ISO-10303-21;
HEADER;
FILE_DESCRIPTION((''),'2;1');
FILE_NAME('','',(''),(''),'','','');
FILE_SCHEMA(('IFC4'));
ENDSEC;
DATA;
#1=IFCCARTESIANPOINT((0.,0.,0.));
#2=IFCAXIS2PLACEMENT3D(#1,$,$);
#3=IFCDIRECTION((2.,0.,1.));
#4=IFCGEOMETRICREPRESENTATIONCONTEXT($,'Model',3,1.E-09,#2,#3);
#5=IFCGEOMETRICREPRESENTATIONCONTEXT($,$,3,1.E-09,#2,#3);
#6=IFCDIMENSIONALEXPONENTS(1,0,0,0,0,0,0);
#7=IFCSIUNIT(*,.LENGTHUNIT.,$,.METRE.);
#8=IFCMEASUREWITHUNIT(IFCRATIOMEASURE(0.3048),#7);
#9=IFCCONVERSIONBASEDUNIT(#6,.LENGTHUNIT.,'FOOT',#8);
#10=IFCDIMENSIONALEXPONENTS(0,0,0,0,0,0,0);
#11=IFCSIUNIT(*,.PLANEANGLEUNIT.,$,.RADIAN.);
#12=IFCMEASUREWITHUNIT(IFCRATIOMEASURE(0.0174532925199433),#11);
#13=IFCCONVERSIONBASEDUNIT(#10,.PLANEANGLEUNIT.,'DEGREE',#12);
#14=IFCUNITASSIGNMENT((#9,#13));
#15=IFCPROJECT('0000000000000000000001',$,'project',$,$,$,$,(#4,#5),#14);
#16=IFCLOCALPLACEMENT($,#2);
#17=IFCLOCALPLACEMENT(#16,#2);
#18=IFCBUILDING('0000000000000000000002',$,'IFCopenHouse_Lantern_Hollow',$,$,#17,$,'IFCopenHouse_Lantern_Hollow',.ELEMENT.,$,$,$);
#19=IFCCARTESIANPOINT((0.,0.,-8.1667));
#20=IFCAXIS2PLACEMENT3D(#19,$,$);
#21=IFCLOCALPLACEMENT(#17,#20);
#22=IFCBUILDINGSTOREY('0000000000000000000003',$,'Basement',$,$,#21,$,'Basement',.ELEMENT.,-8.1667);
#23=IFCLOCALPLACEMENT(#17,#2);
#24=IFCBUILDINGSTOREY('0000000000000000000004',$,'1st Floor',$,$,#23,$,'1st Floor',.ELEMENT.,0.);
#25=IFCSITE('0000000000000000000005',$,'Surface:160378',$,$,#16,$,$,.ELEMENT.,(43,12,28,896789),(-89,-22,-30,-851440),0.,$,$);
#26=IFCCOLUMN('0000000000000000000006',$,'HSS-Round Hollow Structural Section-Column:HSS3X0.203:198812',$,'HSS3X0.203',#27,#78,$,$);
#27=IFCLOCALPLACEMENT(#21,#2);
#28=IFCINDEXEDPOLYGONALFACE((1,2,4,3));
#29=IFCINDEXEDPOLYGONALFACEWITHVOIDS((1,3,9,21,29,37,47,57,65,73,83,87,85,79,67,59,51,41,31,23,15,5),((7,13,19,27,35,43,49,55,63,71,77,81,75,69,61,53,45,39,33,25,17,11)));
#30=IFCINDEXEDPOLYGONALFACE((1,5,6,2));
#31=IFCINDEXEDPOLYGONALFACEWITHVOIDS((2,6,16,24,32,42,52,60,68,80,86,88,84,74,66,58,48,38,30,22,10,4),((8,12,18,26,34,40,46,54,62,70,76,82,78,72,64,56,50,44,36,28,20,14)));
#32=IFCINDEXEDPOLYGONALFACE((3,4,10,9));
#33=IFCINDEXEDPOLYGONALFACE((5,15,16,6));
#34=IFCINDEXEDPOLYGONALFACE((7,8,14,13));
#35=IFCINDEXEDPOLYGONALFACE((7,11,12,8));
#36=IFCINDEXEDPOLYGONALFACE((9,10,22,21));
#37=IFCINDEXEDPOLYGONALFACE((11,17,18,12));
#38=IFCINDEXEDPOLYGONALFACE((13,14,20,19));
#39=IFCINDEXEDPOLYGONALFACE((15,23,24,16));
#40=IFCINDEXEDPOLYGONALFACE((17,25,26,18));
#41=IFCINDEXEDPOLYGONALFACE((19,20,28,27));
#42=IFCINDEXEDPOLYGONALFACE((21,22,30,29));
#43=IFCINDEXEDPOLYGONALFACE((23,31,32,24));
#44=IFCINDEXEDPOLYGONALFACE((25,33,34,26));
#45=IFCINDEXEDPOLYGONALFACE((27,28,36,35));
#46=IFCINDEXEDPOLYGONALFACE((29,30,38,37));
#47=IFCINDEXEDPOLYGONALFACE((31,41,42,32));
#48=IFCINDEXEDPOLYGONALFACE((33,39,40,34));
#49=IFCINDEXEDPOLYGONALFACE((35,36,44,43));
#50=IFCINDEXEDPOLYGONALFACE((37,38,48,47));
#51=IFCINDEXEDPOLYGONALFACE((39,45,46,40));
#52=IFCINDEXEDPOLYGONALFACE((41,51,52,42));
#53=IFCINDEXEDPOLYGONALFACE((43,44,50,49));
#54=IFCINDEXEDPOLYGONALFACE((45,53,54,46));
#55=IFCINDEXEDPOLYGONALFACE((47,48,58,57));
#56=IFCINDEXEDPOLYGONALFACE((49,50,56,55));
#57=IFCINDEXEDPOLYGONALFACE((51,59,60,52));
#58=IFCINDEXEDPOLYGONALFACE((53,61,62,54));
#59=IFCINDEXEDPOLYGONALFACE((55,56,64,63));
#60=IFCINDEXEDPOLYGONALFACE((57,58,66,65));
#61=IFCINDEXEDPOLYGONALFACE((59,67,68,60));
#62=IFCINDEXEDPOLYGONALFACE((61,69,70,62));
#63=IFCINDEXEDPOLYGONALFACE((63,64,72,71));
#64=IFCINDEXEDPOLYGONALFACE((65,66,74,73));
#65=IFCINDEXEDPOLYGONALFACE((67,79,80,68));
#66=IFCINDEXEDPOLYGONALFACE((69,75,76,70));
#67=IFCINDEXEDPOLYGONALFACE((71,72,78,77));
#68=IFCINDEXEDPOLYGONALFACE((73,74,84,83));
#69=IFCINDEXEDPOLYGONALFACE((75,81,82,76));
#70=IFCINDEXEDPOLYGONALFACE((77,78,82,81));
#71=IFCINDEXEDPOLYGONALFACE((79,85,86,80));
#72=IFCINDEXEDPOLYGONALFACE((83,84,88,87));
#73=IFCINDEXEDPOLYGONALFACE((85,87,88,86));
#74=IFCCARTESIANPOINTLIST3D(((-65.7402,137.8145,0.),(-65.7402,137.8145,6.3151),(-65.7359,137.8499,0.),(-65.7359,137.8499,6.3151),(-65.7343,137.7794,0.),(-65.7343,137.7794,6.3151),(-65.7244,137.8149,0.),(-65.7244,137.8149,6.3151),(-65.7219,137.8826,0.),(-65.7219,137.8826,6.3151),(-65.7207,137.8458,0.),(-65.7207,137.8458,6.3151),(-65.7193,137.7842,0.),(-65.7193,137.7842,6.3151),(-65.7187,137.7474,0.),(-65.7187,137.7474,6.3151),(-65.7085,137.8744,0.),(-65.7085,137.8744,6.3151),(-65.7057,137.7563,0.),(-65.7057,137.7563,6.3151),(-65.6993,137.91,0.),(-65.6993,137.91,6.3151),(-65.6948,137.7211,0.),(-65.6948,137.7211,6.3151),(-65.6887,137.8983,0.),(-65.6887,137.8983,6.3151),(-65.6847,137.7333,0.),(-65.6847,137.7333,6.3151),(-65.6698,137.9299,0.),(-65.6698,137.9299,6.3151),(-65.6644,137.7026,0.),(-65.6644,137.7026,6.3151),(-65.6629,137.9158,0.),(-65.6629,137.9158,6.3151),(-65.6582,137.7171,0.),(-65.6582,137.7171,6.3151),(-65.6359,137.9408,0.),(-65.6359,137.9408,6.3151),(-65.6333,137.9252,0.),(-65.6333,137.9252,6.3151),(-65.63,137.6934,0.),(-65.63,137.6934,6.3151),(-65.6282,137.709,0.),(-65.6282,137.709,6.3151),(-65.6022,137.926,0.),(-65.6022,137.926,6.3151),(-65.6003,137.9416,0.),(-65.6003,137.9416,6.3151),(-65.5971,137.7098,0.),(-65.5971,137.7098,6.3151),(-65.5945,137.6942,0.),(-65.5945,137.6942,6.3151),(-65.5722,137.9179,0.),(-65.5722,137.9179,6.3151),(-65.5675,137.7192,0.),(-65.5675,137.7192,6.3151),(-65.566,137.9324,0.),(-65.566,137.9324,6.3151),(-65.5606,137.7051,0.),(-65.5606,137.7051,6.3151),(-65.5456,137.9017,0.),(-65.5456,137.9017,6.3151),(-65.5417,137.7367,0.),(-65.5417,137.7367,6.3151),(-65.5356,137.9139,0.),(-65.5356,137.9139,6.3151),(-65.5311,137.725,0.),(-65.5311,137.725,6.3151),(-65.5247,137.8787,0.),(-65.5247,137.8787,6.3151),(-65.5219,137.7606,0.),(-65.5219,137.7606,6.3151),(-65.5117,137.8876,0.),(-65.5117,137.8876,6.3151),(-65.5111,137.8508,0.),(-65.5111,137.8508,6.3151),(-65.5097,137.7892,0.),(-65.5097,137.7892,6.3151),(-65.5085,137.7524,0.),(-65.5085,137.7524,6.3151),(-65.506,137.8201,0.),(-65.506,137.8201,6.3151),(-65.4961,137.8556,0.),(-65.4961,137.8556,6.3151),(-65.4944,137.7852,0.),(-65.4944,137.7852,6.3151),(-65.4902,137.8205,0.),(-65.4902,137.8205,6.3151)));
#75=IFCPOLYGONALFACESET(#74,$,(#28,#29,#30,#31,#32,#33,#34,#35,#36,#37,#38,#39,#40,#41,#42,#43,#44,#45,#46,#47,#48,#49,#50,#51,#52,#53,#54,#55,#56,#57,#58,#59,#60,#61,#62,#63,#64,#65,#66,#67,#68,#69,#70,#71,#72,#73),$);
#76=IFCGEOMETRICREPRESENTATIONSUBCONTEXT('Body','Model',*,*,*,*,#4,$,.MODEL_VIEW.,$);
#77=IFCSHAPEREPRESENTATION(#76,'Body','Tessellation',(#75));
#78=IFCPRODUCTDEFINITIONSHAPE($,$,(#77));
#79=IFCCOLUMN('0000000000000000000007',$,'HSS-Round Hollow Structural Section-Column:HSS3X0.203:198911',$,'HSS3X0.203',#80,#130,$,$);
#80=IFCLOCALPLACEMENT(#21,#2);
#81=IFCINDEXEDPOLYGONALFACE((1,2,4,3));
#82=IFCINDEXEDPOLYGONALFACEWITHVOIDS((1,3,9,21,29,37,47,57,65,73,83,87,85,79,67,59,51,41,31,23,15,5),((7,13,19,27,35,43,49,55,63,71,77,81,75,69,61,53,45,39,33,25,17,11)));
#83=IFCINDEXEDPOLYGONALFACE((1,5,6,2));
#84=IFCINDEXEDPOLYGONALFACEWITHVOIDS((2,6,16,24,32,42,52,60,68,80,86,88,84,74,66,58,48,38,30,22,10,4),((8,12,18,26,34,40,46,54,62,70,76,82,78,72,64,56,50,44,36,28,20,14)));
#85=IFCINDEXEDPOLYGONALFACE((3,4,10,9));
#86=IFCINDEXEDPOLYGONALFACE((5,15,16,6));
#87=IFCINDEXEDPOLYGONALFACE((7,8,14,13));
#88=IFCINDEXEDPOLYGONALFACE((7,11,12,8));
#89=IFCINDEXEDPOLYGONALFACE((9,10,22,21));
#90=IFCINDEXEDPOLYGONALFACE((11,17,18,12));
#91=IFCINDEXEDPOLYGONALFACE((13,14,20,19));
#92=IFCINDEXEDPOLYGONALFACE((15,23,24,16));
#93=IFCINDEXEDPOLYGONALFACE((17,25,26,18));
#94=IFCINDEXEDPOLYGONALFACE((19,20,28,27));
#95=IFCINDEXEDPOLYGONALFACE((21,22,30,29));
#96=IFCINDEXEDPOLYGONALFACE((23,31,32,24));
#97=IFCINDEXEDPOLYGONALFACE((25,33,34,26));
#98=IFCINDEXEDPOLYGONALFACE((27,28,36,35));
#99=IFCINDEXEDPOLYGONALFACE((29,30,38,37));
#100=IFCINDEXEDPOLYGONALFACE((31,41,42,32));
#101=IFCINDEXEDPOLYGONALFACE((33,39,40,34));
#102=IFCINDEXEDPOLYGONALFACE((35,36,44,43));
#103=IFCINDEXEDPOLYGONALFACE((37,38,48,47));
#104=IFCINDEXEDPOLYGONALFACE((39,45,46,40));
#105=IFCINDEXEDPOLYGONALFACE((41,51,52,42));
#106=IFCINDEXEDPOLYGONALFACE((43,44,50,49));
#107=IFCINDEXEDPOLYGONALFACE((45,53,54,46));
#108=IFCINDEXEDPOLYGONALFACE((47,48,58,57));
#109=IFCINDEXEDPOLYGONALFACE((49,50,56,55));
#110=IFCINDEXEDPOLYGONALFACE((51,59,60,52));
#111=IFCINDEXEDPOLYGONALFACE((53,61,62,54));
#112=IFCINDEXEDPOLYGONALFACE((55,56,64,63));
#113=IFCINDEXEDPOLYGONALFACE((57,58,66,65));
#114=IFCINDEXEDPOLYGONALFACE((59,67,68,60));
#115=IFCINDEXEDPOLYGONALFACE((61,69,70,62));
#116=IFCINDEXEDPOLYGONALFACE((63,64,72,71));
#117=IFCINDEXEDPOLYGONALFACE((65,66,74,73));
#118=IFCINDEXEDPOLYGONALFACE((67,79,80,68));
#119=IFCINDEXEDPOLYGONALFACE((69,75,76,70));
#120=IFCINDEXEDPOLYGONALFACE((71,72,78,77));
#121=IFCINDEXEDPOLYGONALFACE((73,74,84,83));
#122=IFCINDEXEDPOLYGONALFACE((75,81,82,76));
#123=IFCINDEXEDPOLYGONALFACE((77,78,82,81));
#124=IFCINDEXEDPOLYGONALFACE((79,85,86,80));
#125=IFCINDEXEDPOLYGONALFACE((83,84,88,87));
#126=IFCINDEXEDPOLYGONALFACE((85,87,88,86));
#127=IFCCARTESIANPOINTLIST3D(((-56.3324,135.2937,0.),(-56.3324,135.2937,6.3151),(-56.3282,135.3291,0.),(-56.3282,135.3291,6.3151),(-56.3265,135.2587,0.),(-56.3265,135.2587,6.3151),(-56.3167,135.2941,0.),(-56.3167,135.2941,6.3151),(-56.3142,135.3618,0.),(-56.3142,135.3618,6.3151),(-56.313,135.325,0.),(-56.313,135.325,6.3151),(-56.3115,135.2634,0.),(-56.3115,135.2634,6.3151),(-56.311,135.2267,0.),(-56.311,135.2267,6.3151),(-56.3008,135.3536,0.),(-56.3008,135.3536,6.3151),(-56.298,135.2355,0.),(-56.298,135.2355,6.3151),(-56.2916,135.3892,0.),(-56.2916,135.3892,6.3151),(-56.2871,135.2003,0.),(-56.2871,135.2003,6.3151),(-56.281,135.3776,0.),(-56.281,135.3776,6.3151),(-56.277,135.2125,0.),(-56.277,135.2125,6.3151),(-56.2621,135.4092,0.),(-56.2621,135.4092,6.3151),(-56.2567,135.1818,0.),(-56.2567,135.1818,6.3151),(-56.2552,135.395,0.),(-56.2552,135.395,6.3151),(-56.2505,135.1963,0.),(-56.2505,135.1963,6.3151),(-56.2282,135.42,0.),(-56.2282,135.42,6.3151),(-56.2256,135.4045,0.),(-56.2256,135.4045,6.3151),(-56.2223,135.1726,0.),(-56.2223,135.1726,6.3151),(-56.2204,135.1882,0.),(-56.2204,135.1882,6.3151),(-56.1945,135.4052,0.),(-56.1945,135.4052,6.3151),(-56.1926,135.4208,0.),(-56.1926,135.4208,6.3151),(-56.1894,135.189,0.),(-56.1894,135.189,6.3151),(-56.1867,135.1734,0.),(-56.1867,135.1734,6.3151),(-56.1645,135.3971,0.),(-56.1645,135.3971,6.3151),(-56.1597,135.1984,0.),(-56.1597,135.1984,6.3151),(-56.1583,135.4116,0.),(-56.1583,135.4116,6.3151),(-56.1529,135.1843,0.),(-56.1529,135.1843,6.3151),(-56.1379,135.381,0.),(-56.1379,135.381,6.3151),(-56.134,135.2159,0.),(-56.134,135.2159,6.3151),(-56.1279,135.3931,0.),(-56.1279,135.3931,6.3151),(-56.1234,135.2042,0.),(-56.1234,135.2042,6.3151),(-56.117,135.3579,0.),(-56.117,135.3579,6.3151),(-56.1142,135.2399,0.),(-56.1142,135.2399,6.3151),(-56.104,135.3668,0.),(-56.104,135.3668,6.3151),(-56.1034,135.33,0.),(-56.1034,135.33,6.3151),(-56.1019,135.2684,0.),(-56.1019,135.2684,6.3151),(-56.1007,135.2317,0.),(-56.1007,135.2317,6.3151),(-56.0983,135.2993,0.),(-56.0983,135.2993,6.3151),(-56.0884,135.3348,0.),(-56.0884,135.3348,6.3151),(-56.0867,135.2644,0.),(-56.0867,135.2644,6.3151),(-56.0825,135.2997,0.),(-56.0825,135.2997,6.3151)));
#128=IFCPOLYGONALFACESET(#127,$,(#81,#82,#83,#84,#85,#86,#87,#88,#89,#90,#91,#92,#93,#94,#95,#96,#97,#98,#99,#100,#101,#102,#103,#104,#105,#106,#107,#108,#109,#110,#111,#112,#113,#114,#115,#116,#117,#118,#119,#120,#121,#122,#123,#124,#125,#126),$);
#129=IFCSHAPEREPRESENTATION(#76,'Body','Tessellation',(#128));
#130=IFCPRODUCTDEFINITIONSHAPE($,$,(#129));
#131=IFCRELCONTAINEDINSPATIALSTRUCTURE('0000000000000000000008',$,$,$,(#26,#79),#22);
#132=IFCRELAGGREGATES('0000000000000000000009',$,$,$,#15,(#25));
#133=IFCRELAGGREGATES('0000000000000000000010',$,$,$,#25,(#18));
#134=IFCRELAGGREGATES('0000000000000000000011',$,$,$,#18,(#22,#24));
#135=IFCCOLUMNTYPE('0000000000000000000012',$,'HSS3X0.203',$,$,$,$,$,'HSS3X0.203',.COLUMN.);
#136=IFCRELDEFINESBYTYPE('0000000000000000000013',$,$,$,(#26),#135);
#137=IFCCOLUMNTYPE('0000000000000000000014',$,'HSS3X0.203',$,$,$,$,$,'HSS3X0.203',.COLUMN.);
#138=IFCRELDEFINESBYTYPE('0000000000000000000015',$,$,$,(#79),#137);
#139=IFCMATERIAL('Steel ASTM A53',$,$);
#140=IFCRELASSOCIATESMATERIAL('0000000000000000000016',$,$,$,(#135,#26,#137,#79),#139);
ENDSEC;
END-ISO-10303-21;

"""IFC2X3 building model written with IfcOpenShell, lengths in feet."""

from ifc_helpers import new_model, entity, si_unit, converted_unit, direction, frame, frame_2d, origin, place, context, subcontext, project, spatial, circle_curve, parameter, trimmed, segment, composite_curve, outline, extrude, source, transform, mapped, material, type_object, type_shapes, element, save


model = new_model("IFC2X3")

# Units and contexts
model_context = context("Model", 3, precision=1e-09, world=origin(), true_north=direction((2.0, 0.0, 1.0)))
context_of_model = context(None, 3, precision=1e-09, world=origin(), true_north=direction((2.0, 0.0, 1.0)))
body_context = subcontext(model_context, "Body", "Model", "MODEL_VIEW")
ifc_project = project(units=[converted_unit("LENGTHUNIT", "FOOT", entity("IfcRatioMeasure", 0.3048), si_unit("LENGTHUNIT", "METRE"), dimensions=[1, 0, 0, 0, 0, 0, 0]), converted_unit("PLANEANGLEUNIT", "DEGREE", entity("IfcRatioMeasure", 0.0174532925199433), si_unit("PLANEANGLEUNIT", "RADIAN"), dimensions=[0, 0, 0, 0, 0, 0, 0])], contexts=[model_context, context_of_model])

# Site, building, storey
site_placement = place(None, origin())
site = spatial("IfcSite", under=ifc_project, at=site_placement, Name="Surface:160378", CompositionType="ELEMENT", RefLatitude=(43, 12, 28, 896789), RefLongitude=(-89, -22, -30, -851440), RefElevation=0.0)
building_placement = place(site_placement, origin())
building = spatial("IfcBuilding", under=site, at=building_placement, Name="IFCopenHouse_Lantern_Hollow", LongName="IFCopenHouse_Lantern_Hollow", CompositionType="ELEMENT")
storey_1_placement = place(building_placement, frame((0.0, 0.0, -8.1667)))
storey_1 = spatial("IfcBuildingStorey", under=building, at=storey_1_placement, Name="Basement", LongName="Basement", CompositionType="ELEMENT", Elevation=-8.1667)

# Columns
ifc_material_1 = material(Name="Steel ASTM A53")
column_type_1 = type_object("IfcColumnType", Name="HSS3X0.203", ElementType="HSS3X0.203", PredefinedType="COLUMN", material=ifc_material_1)
shared_shape_1 = source(origin(), body_context, "Body", "SweptSolid", [
    extrude(outline(composite_curve([segment(trimmed(circle_curve(frame_2d((-65.6152, 137.8175), x_axis=(0.965926, -0.258819)), 0.125), [parameter(0.0)], [parameter(180.0)], True, "PARAMETER"), True, "CONTINUOUS"), segment(trimmed(circle_curve(frame_2d((-65.6152, 137.8175), x_axis=(0.965926, -0.258819)), 0.125), [parameter(180.0)], [parameter(0.0)], True, "PARAMETER"), True, "CONTINUOUS")], self_intersect=False), holes=[composite_curve([segment(trimmed(circle_curve(frame_2d((-65.6152, 137.8175), x_axis=(0.965926, -0.258819)), 0.1092), [parameter(180.0)], [parameter(0.0)], True, "PARAMETER"), False, "CONTINUOUS"), segment(trimmed(circle_curve(frame_2d((-65.6152, 137.8175), x_axis=(0.965926, -0.258819)), 0.1092), [parameter(0.0)], [parameter(180.0)], True, "PARAMETER"), False, "CONTINUOUS")], self_intersect=False)]), origin(), (0.0, 0.0, 1.0), 6.3151),
])
type_shapes(column_type_1, [shared_shape_1])
column_1_placement = place(storey_1_placement, origin())
element("IfcColumn", 1, at=column_1_placement, inside=storey_1, type_object=column_type_1, material=ifc_material_1, Name="HSS-Round Hollow Structural Section-Column:HSS3X0.203:198812", ObjectType="HSS3X0.203", context=body_context, shape_type="MappedRepresentation", body=[
    mapped(shared_shape_1, transform((0.0, 0.0, 0.0), scale=1.0)),
])
column_type_2 = type_object("IfcColumnType", Name="HSS3X0.203", ElementType="HSS3X0.203", PredefinedType="COLUMN", material=ifc_material_1)
shared_shape_2 = source(origin(), body_context, "Body", "SweptSolid", [
    extrude(outline(composite_curve([segment(trimmed(circle_curve(frame_2d((-56.2075, 135.2967), x_axis=(0.965926, -0.258819)), 0.125), [parameter(0.0)], [parameter(180.0)], True, "PARAMETER"), True, "CONTINUOUS"), segment(trimmed(circle_curve(frame_2d((-56.2075, 135.2967), x_axis=(0.965926, -0.258819)), 0.125), [parameter(180.0)], [parameter(0.0)], True, "PARAMETER"), True, "CONTINUOUS")], self_intersect=False), holes=[composite_curve([segment(trimmed(circle_curve(frame_2d((-56.2075, 135.2967), x_axis=(0.965926, -0.258819)), 0.1092), [parameter(180.0)], [parameter(0.0)], True, "PARAMETER"), False, "CONTINUOUS"), segment(trimmed(circle_curve(frame_2d((-56.2075, 135.2967), x_axis=(0.965926, -0.258819)), 0.1092), [parameter(0.0)], [parameter(180.0)], True, "PARAMETER"), False, "CONTINUOUS")], self_intersect=False)]), origin(), (0.0, 0.0, 1.0), 6.3151),
])
type_shapes(column_type_2, [shared_shape_2])
column_2_placement = place(storey_1_placement, origin())
element("IfcColumn", 2, at=column_2_placement, inside=storey_1, type_object=column_type_2, material=ifc_material_1, Name="HSS-Round Hollow Structural Section-Column:HSS3X0.203:198911", ObjectType="HSS3X0.203", context=body_context, shape_type="MappedRepresentation", body=[
    mapped(shared_shape_2, transform((0.0, 0.0, 0.0), scale=1.0)),
])

# Shared definitions
storey_2_placement = place(building_placement, origin())
storey_2 = spatial("IfcBuildingStorey", under=building, at=storey_2_placement, Name="1st Floor", LongName="1st Floor", CompositionType="ELEMENT", Elevation=0.0)

save(model, "model.ifc")
